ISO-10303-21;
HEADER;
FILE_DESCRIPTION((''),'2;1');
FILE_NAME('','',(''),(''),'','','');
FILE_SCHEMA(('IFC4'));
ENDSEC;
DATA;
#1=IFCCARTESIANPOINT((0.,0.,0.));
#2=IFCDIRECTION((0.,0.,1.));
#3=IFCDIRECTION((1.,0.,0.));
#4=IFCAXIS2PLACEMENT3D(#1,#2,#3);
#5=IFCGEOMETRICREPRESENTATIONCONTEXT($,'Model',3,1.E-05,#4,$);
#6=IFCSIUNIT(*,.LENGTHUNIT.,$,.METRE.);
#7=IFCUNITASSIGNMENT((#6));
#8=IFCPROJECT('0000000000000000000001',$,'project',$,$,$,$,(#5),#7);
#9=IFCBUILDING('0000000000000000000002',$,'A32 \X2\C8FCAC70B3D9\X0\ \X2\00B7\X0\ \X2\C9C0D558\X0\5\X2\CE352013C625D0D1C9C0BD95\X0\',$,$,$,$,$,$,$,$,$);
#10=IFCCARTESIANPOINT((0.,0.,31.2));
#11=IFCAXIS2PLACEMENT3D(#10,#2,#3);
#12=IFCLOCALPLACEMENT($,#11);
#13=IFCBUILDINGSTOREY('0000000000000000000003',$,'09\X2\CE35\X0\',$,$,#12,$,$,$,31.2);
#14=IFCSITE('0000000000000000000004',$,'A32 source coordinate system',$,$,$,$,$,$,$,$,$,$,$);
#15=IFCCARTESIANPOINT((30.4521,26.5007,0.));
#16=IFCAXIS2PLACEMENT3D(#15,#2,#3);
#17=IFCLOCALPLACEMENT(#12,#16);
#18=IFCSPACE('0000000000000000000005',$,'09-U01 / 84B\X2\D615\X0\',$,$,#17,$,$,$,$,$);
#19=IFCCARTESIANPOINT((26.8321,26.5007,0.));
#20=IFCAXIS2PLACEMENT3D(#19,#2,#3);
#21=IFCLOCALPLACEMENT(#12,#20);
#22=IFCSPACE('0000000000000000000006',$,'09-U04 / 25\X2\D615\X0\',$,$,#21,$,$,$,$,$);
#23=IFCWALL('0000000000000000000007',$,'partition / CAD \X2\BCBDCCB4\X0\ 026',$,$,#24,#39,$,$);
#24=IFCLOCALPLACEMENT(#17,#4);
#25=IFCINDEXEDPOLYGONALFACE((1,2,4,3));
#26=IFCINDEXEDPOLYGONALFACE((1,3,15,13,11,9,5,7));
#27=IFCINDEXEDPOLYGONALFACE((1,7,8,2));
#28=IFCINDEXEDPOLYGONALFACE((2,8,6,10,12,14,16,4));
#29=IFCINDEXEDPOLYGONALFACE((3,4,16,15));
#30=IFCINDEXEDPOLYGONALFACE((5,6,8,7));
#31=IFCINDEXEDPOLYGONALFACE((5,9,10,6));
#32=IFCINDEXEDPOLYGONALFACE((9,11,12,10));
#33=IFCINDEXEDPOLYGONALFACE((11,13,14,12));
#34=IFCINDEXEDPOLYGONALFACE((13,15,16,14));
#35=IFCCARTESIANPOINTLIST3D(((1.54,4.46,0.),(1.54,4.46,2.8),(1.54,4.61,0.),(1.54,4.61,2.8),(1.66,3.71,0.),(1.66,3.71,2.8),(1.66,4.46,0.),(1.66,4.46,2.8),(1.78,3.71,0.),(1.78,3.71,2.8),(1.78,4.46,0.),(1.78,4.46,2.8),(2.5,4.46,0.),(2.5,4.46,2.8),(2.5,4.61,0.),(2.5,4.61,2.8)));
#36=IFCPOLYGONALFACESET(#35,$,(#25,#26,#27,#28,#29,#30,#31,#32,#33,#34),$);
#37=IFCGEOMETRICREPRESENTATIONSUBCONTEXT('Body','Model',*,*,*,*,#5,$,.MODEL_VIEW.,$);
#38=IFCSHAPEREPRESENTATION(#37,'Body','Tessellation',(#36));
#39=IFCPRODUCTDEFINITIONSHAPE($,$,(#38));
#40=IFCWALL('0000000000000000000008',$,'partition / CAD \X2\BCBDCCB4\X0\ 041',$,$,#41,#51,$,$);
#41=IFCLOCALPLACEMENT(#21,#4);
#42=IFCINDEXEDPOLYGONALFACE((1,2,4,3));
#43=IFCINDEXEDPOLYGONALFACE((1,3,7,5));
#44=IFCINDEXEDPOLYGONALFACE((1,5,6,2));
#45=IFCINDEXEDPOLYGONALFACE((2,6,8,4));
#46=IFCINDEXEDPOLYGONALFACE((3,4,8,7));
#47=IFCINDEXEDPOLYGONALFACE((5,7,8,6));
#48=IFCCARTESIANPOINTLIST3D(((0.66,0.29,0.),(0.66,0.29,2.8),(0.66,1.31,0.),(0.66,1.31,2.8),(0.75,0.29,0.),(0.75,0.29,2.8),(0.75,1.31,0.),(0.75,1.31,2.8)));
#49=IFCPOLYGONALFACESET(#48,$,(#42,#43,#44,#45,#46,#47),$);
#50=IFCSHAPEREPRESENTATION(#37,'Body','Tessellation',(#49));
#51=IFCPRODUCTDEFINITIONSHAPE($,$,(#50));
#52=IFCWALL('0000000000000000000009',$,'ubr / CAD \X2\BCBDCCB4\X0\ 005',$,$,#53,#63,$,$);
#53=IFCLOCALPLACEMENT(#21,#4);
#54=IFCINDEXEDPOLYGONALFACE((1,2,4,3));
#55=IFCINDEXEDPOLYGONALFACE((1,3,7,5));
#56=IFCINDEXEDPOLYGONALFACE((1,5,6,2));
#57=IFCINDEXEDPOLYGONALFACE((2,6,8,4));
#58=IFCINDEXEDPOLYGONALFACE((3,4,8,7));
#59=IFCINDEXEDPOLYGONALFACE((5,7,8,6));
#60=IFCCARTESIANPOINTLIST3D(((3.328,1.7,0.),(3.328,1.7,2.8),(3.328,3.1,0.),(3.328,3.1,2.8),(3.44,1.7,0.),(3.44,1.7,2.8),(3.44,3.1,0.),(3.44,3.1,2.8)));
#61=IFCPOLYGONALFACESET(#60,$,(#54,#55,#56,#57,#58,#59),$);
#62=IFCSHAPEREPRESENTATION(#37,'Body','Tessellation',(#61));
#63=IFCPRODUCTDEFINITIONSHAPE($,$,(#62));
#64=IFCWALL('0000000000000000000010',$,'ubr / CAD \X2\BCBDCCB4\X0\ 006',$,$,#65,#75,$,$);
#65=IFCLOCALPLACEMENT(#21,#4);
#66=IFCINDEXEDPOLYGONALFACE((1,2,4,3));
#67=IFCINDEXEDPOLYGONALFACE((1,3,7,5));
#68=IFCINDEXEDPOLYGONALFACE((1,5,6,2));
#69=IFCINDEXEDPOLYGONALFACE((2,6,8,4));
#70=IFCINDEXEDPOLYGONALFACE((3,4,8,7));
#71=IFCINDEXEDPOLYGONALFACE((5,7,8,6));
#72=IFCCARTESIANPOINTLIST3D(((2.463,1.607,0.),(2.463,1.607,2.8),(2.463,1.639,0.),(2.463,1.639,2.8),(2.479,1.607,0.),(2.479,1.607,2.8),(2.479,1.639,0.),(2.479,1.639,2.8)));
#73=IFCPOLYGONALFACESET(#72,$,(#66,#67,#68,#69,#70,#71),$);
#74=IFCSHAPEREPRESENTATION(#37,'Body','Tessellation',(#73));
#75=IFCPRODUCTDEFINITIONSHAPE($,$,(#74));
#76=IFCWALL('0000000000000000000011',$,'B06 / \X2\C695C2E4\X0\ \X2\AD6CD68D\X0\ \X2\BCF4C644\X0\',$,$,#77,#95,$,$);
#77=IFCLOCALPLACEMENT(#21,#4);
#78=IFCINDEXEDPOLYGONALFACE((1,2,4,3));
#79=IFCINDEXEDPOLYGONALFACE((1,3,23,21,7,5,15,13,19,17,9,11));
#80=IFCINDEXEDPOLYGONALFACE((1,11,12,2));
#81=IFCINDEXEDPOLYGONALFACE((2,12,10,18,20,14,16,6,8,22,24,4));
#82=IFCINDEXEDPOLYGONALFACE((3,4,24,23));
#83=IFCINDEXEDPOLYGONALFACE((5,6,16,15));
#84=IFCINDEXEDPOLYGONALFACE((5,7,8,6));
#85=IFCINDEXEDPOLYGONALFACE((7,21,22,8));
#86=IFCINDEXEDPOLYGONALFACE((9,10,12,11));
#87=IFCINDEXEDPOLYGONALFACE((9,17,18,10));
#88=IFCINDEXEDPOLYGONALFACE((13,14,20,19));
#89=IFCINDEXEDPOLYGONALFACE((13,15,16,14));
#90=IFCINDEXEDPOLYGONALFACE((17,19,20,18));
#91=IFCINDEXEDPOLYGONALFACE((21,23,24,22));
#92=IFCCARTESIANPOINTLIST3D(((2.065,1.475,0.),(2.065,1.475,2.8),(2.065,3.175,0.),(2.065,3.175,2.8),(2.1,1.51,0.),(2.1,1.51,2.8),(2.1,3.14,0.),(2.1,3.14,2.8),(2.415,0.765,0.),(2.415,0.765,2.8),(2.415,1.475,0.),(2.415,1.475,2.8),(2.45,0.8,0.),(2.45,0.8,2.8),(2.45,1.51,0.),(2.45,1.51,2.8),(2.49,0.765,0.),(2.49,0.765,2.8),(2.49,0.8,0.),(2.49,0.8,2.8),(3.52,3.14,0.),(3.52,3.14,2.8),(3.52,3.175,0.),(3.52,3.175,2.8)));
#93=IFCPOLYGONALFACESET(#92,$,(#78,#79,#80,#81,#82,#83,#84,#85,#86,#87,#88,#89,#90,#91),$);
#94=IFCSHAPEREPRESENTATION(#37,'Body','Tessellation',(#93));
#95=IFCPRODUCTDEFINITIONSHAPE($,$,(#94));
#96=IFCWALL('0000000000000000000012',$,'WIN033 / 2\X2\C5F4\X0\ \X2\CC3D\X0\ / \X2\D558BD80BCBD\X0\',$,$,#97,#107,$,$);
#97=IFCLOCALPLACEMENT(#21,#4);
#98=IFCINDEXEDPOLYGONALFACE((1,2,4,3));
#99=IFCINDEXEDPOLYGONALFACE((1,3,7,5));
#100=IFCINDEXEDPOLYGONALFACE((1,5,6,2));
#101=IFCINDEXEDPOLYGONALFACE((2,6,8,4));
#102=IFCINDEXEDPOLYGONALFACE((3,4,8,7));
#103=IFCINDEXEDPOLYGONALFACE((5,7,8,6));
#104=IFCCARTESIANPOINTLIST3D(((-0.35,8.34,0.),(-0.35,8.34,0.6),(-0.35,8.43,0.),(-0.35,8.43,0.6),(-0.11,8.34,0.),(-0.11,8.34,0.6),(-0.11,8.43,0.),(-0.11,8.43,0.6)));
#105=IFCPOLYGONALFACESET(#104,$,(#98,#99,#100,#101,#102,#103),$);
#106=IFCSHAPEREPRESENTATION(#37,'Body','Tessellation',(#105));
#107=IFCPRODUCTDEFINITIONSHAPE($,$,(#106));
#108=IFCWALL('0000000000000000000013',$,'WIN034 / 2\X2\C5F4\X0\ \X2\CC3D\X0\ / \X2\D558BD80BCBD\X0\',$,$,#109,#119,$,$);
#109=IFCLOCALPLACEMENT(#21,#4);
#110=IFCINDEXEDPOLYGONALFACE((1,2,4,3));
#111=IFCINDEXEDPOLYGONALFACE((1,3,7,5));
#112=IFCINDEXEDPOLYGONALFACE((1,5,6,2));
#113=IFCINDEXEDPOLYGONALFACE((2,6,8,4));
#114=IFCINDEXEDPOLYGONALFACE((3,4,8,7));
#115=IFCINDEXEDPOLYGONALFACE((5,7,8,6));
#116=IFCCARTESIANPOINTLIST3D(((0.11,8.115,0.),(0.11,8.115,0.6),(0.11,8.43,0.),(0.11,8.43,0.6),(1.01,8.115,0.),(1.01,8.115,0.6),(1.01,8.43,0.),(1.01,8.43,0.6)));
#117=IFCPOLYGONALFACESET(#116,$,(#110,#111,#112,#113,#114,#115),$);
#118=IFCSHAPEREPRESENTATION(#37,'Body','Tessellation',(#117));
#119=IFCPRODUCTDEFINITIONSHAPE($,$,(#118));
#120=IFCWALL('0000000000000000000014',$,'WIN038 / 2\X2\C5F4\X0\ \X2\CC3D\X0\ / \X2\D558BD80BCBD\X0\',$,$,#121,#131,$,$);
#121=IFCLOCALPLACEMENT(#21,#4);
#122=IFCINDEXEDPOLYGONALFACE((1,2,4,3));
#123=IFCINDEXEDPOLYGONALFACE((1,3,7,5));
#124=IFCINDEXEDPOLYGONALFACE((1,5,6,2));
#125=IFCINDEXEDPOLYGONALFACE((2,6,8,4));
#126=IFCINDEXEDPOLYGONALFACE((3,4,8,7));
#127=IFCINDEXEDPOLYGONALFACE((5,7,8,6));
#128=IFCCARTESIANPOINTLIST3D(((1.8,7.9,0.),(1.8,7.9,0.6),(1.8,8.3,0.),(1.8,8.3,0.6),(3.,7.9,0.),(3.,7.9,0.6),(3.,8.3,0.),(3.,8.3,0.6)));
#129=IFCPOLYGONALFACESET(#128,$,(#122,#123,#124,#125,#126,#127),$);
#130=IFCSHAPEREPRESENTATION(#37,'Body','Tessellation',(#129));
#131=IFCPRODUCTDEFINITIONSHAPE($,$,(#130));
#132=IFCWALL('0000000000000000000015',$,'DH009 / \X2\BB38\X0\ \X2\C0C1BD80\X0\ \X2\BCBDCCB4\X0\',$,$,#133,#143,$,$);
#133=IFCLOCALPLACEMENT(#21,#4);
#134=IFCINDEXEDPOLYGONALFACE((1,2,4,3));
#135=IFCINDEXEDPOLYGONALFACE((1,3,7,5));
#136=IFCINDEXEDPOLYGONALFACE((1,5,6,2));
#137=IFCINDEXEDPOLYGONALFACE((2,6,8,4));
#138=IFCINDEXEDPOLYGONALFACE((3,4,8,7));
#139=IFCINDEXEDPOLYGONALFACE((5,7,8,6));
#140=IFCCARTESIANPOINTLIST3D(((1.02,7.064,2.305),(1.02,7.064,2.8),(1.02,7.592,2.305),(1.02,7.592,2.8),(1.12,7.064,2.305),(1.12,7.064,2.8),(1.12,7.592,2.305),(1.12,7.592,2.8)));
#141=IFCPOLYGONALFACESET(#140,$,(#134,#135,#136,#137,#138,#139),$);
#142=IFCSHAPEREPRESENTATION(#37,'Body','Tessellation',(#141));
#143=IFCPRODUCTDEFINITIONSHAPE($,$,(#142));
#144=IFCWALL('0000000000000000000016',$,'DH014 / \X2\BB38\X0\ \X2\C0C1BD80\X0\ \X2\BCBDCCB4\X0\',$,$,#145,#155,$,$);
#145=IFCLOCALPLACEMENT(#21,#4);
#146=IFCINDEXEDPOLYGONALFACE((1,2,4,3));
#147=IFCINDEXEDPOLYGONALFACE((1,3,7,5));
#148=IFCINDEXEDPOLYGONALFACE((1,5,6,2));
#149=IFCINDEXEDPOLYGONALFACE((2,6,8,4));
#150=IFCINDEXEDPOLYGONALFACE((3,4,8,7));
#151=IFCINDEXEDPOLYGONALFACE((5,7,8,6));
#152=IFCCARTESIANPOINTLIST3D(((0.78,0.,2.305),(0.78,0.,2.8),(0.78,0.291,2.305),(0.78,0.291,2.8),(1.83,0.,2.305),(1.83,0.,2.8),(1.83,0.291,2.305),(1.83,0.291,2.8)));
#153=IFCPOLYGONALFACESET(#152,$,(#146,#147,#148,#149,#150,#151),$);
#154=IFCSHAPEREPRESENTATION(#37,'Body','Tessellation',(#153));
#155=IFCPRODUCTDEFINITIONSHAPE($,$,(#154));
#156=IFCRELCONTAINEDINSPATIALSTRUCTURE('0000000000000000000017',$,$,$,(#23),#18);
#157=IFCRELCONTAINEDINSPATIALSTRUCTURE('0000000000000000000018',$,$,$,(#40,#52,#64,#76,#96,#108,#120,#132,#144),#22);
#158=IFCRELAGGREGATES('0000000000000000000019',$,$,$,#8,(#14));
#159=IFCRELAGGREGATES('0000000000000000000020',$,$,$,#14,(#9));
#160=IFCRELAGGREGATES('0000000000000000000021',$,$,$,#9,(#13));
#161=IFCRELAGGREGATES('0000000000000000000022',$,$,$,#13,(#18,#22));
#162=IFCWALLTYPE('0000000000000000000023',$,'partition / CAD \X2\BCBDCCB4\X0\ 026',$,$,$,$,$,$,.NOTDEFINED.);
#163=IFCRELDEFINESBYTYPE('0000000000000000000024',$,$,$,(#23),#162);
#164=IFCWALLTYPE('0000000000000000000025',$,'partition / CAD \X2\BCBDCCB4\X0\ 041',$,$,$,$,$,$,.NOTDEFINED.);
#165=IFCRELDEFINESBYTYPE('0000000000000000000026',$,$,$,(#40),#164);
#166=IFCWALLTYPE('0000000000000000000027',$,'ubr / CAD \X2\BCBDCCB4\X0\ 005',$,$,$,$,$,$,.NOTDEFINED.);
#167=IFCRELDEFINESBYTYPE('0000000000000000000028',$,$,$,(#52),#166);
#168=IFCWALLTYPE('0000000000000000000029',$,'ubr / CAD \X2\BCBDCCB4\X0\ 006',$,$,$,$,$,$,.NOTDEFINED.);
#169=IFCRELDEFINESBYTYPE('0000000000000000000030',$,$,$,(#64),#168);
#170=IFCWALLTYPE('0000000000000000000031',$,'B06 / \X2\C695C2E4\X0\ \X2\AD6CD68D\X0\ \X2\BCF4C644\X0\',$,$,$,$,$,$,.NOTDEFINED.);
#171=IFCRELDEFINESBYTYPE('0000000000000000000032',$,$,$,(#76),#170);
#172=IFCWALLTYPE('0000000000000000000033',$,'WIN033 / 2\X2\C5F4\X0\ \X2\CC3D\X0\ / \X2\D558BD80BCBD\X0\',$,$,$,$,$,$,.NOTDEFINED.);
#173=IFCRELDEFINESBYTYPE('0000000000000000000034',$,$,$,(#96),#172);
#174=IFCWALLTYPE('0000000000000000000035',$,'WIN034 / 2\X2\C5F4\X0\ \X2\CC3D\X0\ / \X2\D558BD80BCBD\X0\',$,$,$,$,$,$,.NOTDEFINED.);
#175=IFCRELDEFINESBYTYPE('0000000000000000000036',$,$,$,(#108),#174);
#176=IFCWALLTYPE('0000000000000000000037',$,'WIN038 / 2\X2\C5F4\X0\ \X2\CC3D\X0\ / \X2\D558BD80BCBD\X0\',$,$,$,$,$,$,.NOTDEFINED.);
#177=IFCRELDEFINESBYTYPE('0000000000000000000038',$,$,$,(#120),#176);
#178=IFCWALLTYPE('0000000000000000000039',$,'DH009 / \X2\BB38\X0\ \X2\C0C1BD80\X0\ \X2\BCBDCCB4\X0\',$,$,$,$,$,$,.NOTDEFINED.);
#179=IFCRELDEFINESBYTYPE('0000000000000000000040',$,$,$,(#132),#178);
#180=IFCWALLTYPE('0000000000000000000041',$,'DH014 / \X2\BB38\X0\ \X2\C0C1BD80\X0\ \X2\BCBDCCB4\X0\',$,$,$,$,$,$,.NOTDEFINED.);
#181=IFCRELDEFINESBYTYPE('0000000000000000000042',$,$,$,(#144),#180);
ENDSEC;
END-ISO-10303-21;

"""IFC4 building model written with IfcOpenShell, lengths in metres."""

from ifc_helpers import new_model, si_unit, frame, origin, origin_with_axes, place, context, subcontext, project, spatial, polyline, outline, extrude, source, transform, mapped, type_object, type_shapes, element, save


model = new_model("IFC4")

# Units and contexts
model_context = context("Model", 3, precision=1e-05, world=origin_with_axes())
body_context = subcontext(model_context, "Body", "Model", "MODEL_VIEW")
ifc_project = project(units=[si_unit("LENGTHUNIT", "METRE")], contexts=[model_context])

# Site, building, storey, space
site = spatial("IfcSite", under=ifc_project, Name="A32 source coordinate system")
building = spatial("IfcBuilding", under=site, Name="A32 주거동 · 지하5층–옥탑지붕")
storey_placement = place(None, frame((0.0, 0.0, 31.2), z_axis=(0.0, 0.0, 1.0), x_axis=(1.0, 0.0, 0.0)))
storey = spatial("IfcBuildingStorey", under=building, at=storey_placement, Name="09층", Elevation=31.2)
space_1_placement = place(storey_placement, frame((30.4521, 26.5007, 0.0), z_axis=(0.0, 0.0, 1.0), x_axis=(1.0, 0.0, 0.0)))
space_1 = spatial("IfcSpace", under=storey, at=space_1_placement, Name="09-U01 / 84B형")

# Wall
wall_type_1 = type_object("IfcWallType", Name="partition / CAD 벽체 026", PredefinedType="NOTDEFINED")
shared_shape_1 = source(origin(), body_context, "Body", "SweptSolid", [
    extrude(outline(polyline([(1.54, 4.46), (1.54, 4.61), (2.5, 4.61), (2.5, 4.46), (1.78, 4.46), (1.78, 3.71), (1.66, 3.71), (1.66, 4.46), (1.54, 4.46)])), origin(), (0.0, 0.0, 1.0), 2.8),
])
type_shapes(wall_type_1, [shared_shape_1])
wall_1_placement = place(space_1_placement, origin_with_axes())
element("IfcWall", 1, at=wall_1_placement, inside=space_1, type_object=wall_type_1, Name="partition / CAD 벽체 026", context=body_context, shape_type="MappedRepresentation", body=[
    mapped(shared_shape_1, transform((0.0, 0.0, 0.0), scale=1.0)),
])

# Shared definitions
space_2_placement = place(storey_placement, frame((26.8321, 26.5007, 0.0), z_axis=(0.0, 0.0, 1.0), x_axis=(1.0, 0.0, 0.0)))
space_2 = spatial("IfcSpace", under=storey, at=space_2_placement, Name="09-U04 / 25형")

# Walls
wall_type_2 = type_object("IfcWallType", Name="partition / CAD 벽체 041", PredefinedType="NOTDEFINED")
shared_shape_2 = source(origin(), body_context, "Body", "SweptSolid", [
    extrude(outline(polyline([(0.75, 1.31), (0.75, 0.29), (0.66, 0.29), (0.66, 1.31), (0.75, 1.31)])), origin(), (0.0, 0.0, 1.0), 2.8),
])
type_shapes(wall_type_2, [shared_shape_2])
wall_2_placement = place(space_2_placement, origin_with_axes())
element("IfcWall", 2, at=wall_2_placement, inside=space_2, type_object=wall_type_2, Name="partition / CAD 벽체 041", context=body_context, shape_type="MappedRepresentation", body=[
    mapped(shared_shape_2, transform((0.0, 0.0, 0.0), scale=1.0)),
])
wall_type_3 = type_object("IfcWallType", Name="ubr / CAD 벽체 005", PredefinedType="NOTDEFINED")
shared_shape_3 = source(origin(), body_context, "Body", "SweptSolid", [
    extrude(outline(polyline([(3.44, 3.1), (3.44, 1.7), (3.328, 1.7), (3.328, 3.1), (3.44, 3.1)])), origin(), (0.0, 0.0, 1.0), 2.8),
])
type_shapes(wall_type_3, [shared_shape_3])
wall_3_placement = place(space_2_placement, origin_with_axes())
element("IfcWall", 3, at=wall_3_placement, inside=space_2, type_object=wall_type_3, Name="ubr / CAD 벽체 005", context=body_context, shape_type="MappedRepresentation", body=[
    mapped(shared_shape_3, transform((0.0, 0.0, 0.0), scale=1.0)),
])
wall_type_4 = type_object("IfcWallType", Name="ubr / CAD 벽체 006", PredefinedType="NOTDEFINED")
shared_shape_4 = source(origin(), body_context, "Body", "SweptSolid", [
    extrude(outline(polyline([(2.463, 1.639), (2.479, 1.639), (2.479, 1.607), (2.463, 1.607), (2.463, 1.639)])), origin(), (0.0, 0.0, 1.0), 2.8),
])
type_shapes(wall_type_4, [shared_shape_4])
wall_4_placement = place(space_2_placement, origin_with_axes())
element("IfcWall", 4, at=wall_4_placement, inside=space_2, type_object=wall_type_4, Name="ubr / CAD 벽체 006", context=body_context, shape_type="MappedRepresentation", body=[
    mapped(shared_shape_4, transform((0.0, 0.0, 0.0), scale=1.0)),
])
wall_type_5 = type_object("IfcWallType", Name="B06 / 욕실 구획 보완", PredefinedType="NOTDEFINED")
shared_shape_5 = source(origin(), body_context, "Body", "SweptSolid", [
    extrude(outline(polyline([(3.52, 3.14), (2.1, 3.14), (2.1, 1.51), (2.45, 1.51), (2.45, 0.8), (2.49, 0.8), (2.49, 0.765), (2.415, 0.765), (2.415, 1.475), (2.065, 1.475), (2.065, 3.175), (3.52, 3.175), (3.52, 3.14)])), origin(), (0.0, 0.0, 1.0), 2.8),
])
type_shapes(wall_type_5, [shared_shape_5])
wall_5_placement = place(space_2_placement, origin_with_axes())
element("IfcWall", 5, at=wall_5_placement, inside=space_2, type_object=wall_type_5, Name="B06 / 욕실 구획 보완", context=body_context, shape_type="MappedRepresentation", body=[
    mapped(shared_shape_5, transform((0.0, 0.0, 0.0), scale=1.0)),
])
wall_type_6 = type_object("IfcWallType", Name="WIN033 / 2열 창 / 하부벽", PredefinedType="NOTDEFINED")
shared_shape_6 = source(origin(), body_context, "Body", "SweptSolid", [
    extrude(outline(polyline([(-0.11, 8.43), (-0.11, 8.34), (-0.35, 8.34), (-0.35, 8.43), (-0.11, 8.43)])), origin(), (0.0, 0.0, 1.0), 0.6),
])
type_shapes(wall_type_6, [shared_shape_6])
wall_6_placement = place(space_2_placement, origin_with_axes())
element("IfcWall", 6, at=wall_6_placement, inside=space_2, type_object=wall_type_6, Name="WIN033 / 2열 창 / 하부벽", context=body_context, shape_type="MappedRepresentation", body=[
    mapped(shared_shape_6, transform((0.0, 0.0, 0.0), scale=1.0)),
])
wall_type_7 = type_object("IfcWallType", Name="WIN034 / 2열 창 / 하부벽", PredefinedType="NOTDEFINED")
shared_shape_7 = source(origin(), body_context, "Body", "SweptSolid", [
    extrude(outline(polyline([(0.11, 8.115), (0.11, 8.43), (1.01, 8.43), (1.01, 8.115), (0.11, 8.115)])), origin(), (0.0, 0.0, 1.0), 0.6),
])
type_shapes(wall_type_7, [shared_shape_7])
wall_7_placement = place(space_2_placement, origin_with_axes())
element("IfcWall", 7, at=wall_7_placement, inside=space_2, type_object=wall_type_7, Name="WIN034 / 2열 창 / 하부벽", context=body_context, shape_type="MappedRepresentation", body=[
    mapped(shared_shape_7, transform((0.0, 0.0, 0.0), scale=1.0)),
])
wall_type_8 = type_object("IfcWallType", Name="WIN038 / 2열 창 / 하부벽", PredefinedType="NOTDEFINED")
shared_shape_8 = source(origin(), body_context, "Body", "SweptSolid", [
    extrude(outline(polyline([(1.8, 7.9), (1.8, 8.3), (3.0, 8.3), (3.0, 7.9), (1.8, 7.9)])), origin(), (0.0, 0.0, 1.0), 0.6),
])
type_shapes(wall_type_8, [shared_shape_8])
wall_8_placement = place(space_2_placement, origin_with_axes())
element("IfcWall", 8, at=wall_8_placement, inside=space_2, type_object=wall_type_8, Name="WIN038 / 2열 창 / 하부벽", context=body_context, shape_type="MappedRepresentation", body=[
    mapped(shared_shape_8, transform((0.0, 0.0, 0.0), scale=1.0)),
])
wall_type_9 = type_object("IfcWallType", Name="DH009 / 문 상부 벽체", PredefinedType="NOTDEFINED")
shared_shape_9 = source(origin(), body_context, "Body", "SweptSolid", [
    extrude(outline(polyline([(1.02, 7.064), (1.02, 7.592), (1.12, 7.592), (1.12, 7.064), (1.02, 7.064)])), frame((0.0, 0.0, 2.305)), (0.0, 0.0, 1.0), 0.495),
])
type_shapes(wall_type_9, [shared_shape_9])
wall_9_placement = place(space_2_placement, origin_with_axes())
element("IfcWall", 9, at=wall_9_placement, inside=space_2, type_object=wall_type_9, Name="DH009 / 문 상부 벽체", context=body_context, shape_type="MappedRepresentation", body=[
    mapped(shared_shape_9, transform((0.0, 0.0, 0.0), scale=1.0)),
])
wall_type_10 = type_object("IfcWallType", Name="DH014 / 문 상부 벽체", PredefinedType="NOTDEFINED")
shared_shape_10 = source(origin(), body_context, "Body", "SweptSolid", [
    extrude(outline(polyline([(0.78, 0.291), (1.83, 0.291), (1.83, 0.0), (0.78, 0.0), (0.78, 0.291)])), frame((0.0, 0.0, 2.305)), (0.0, 0.0, 1.0), 0.495),
])
type_shapes(wall_type_10, [shared_shape_10])
wall_10_placement = place(space_2_placement, origin_with_axes())
element("IfcWall", 10, at=wall_10_placement, inside=space_2, type_object=wall_type_10, Name="DH014 / 문 상부 벽체", context=body_context, shape_type="MappedRepresentation", body=[
    mapped(shared_shape_10, transform((0.0, 0.0, 0.0), scale=1.0)),
])

save(model, "model.ifc")
